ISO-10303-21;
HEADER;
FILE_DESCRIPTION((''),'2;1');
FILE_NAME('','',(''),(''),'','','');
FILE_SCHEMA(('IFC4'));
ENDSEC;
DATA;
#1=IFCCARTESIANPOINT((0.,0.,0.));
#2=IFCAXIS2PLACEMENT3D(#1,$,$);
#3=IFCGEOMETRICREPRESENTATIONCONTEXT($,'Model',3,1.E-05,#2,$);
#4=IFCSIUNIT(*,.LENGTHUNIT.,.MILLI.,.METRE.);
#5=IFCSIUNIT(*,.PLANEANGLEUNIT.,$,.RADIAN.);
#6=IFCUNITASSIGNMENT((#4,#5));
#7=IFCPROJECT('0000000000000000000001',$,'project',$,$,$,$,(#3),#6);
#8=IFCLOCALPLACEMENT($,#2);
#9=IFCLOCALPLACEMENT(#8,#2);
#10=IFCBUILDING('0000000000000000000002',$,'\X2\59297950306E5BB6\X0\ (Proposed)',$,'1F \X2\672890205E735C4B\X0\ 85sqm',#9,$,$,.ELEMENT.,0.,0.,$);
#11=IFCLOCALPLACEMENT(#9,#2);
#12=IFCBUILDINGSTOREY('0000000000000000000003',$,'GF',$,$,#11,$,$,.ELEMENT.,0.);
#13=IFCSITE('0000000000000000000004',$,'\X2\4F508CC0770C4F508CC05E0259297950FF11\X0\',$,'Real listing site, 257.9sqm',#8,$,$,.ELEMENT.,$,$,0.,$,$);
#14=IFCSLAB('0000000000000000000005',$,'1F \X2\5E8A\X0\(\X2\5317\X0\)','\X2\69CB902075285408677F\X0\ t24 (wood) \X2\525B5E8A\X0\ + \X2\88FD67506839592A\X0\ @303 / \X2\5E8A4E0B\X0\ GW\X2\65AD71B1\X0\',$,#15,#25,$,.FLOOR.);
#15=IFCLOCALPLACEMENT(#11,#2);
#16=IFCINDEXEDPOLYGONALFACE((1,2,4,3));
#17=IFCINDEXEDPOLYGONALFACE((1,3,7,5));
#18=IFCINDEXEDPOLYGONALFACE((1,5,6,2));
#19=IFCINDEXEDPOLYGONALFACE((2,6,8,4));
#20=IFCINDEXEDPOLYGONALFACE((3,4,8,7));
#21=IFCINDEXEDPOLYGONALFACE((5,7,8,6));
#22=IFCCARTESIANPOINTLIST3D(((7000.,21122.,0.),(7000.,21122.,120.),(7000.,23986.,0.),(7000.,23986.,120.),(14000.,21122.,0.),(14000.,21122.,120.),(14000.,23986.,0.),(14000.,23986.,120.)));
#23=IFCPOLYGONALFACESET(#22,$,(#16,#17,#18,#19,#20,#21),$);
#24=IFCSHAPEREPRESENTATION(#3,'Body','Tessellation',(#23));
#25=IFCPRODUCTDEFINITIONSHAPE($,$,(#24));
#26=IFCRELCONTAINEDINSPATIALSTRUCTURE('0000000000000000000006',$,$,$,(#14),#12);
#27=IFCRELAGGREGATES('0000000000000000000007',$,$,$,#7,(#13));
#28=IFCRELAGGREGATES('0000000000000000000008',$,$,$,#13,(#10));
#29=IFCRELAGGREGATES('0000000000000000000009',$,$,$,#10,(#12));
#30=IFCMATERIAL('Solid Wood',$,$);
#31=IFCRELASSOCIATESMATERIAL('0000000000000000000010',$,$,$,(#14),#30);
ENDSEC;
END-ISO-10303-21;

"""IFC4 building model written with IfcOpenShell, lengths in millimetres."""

from ifc_helpers import new_model, si_unit, frame, frame_2d, origin, place, context, project, spatial, rectangle, extrude, material, element, save


model = new_model("IFC4")

# Units and contexts
model_context = context("Model", 3, precision=1e-05, world=origin())
ifc_project = project(units=[si_unit("LENGTHUNIT", "METRE", prefix="MILLI"), si_unit("PLANEANGLEUNIT", "RADIAN")], contexts=[model_context])

# Site, building, storey
site_placement = place(None, origin())
site = spatial("IfcSite", under=ifc_project, at=site_placement, Name="佐賀県佐賀市天祐１", ObjectType="Real listing site, 257.9sqm", CompositionType="ELEMENT", RefElevation=0.0)
building_placement = place(site_placement, origin())
building = spatial("IfcBuilding", under=site, at=building_placement, Name="天祐の家 (Proposed)", ObjectType="1F 木造平屋 85sqm", CompositionType="ELEMENT", ElevationOfRefHeight=0.0, ElevationOfTerrain=0.0)
storey_placement = place(building_placement, origin())
storey = spatial("IfcBuildingStorey", under=building, at=storey_placement, Name="GF", CompositionType="ELEMENT", Elevation=0.0)

# Slab
ifc_material_1 = material(Name="Solid Wood")
slab_1_placement = place(storey_placement, frame((3500.0, 10561.0, 0.0)))
element("IfcSlab", 1, at=slab_1_placement, inside=storey, material=ifc_material_1, Name="1F 床(北)", Description="構造用合板 t24 (wood) 剛床 + 製材根太 @303 / 床下 GW断熱", PredefinedType="FLOOR", context=model_context, shape_type="SweptSolid", body=[
    extrude(rectangle(XDim=7000.0, YDim=2864.0, at=frame_2d((3500.0, 1432.0))), frame((3500.0, 10561.0, 0.0)), (0.0, 0.0, 1.0), 120.0),
])

save(model, "model.ifc")
